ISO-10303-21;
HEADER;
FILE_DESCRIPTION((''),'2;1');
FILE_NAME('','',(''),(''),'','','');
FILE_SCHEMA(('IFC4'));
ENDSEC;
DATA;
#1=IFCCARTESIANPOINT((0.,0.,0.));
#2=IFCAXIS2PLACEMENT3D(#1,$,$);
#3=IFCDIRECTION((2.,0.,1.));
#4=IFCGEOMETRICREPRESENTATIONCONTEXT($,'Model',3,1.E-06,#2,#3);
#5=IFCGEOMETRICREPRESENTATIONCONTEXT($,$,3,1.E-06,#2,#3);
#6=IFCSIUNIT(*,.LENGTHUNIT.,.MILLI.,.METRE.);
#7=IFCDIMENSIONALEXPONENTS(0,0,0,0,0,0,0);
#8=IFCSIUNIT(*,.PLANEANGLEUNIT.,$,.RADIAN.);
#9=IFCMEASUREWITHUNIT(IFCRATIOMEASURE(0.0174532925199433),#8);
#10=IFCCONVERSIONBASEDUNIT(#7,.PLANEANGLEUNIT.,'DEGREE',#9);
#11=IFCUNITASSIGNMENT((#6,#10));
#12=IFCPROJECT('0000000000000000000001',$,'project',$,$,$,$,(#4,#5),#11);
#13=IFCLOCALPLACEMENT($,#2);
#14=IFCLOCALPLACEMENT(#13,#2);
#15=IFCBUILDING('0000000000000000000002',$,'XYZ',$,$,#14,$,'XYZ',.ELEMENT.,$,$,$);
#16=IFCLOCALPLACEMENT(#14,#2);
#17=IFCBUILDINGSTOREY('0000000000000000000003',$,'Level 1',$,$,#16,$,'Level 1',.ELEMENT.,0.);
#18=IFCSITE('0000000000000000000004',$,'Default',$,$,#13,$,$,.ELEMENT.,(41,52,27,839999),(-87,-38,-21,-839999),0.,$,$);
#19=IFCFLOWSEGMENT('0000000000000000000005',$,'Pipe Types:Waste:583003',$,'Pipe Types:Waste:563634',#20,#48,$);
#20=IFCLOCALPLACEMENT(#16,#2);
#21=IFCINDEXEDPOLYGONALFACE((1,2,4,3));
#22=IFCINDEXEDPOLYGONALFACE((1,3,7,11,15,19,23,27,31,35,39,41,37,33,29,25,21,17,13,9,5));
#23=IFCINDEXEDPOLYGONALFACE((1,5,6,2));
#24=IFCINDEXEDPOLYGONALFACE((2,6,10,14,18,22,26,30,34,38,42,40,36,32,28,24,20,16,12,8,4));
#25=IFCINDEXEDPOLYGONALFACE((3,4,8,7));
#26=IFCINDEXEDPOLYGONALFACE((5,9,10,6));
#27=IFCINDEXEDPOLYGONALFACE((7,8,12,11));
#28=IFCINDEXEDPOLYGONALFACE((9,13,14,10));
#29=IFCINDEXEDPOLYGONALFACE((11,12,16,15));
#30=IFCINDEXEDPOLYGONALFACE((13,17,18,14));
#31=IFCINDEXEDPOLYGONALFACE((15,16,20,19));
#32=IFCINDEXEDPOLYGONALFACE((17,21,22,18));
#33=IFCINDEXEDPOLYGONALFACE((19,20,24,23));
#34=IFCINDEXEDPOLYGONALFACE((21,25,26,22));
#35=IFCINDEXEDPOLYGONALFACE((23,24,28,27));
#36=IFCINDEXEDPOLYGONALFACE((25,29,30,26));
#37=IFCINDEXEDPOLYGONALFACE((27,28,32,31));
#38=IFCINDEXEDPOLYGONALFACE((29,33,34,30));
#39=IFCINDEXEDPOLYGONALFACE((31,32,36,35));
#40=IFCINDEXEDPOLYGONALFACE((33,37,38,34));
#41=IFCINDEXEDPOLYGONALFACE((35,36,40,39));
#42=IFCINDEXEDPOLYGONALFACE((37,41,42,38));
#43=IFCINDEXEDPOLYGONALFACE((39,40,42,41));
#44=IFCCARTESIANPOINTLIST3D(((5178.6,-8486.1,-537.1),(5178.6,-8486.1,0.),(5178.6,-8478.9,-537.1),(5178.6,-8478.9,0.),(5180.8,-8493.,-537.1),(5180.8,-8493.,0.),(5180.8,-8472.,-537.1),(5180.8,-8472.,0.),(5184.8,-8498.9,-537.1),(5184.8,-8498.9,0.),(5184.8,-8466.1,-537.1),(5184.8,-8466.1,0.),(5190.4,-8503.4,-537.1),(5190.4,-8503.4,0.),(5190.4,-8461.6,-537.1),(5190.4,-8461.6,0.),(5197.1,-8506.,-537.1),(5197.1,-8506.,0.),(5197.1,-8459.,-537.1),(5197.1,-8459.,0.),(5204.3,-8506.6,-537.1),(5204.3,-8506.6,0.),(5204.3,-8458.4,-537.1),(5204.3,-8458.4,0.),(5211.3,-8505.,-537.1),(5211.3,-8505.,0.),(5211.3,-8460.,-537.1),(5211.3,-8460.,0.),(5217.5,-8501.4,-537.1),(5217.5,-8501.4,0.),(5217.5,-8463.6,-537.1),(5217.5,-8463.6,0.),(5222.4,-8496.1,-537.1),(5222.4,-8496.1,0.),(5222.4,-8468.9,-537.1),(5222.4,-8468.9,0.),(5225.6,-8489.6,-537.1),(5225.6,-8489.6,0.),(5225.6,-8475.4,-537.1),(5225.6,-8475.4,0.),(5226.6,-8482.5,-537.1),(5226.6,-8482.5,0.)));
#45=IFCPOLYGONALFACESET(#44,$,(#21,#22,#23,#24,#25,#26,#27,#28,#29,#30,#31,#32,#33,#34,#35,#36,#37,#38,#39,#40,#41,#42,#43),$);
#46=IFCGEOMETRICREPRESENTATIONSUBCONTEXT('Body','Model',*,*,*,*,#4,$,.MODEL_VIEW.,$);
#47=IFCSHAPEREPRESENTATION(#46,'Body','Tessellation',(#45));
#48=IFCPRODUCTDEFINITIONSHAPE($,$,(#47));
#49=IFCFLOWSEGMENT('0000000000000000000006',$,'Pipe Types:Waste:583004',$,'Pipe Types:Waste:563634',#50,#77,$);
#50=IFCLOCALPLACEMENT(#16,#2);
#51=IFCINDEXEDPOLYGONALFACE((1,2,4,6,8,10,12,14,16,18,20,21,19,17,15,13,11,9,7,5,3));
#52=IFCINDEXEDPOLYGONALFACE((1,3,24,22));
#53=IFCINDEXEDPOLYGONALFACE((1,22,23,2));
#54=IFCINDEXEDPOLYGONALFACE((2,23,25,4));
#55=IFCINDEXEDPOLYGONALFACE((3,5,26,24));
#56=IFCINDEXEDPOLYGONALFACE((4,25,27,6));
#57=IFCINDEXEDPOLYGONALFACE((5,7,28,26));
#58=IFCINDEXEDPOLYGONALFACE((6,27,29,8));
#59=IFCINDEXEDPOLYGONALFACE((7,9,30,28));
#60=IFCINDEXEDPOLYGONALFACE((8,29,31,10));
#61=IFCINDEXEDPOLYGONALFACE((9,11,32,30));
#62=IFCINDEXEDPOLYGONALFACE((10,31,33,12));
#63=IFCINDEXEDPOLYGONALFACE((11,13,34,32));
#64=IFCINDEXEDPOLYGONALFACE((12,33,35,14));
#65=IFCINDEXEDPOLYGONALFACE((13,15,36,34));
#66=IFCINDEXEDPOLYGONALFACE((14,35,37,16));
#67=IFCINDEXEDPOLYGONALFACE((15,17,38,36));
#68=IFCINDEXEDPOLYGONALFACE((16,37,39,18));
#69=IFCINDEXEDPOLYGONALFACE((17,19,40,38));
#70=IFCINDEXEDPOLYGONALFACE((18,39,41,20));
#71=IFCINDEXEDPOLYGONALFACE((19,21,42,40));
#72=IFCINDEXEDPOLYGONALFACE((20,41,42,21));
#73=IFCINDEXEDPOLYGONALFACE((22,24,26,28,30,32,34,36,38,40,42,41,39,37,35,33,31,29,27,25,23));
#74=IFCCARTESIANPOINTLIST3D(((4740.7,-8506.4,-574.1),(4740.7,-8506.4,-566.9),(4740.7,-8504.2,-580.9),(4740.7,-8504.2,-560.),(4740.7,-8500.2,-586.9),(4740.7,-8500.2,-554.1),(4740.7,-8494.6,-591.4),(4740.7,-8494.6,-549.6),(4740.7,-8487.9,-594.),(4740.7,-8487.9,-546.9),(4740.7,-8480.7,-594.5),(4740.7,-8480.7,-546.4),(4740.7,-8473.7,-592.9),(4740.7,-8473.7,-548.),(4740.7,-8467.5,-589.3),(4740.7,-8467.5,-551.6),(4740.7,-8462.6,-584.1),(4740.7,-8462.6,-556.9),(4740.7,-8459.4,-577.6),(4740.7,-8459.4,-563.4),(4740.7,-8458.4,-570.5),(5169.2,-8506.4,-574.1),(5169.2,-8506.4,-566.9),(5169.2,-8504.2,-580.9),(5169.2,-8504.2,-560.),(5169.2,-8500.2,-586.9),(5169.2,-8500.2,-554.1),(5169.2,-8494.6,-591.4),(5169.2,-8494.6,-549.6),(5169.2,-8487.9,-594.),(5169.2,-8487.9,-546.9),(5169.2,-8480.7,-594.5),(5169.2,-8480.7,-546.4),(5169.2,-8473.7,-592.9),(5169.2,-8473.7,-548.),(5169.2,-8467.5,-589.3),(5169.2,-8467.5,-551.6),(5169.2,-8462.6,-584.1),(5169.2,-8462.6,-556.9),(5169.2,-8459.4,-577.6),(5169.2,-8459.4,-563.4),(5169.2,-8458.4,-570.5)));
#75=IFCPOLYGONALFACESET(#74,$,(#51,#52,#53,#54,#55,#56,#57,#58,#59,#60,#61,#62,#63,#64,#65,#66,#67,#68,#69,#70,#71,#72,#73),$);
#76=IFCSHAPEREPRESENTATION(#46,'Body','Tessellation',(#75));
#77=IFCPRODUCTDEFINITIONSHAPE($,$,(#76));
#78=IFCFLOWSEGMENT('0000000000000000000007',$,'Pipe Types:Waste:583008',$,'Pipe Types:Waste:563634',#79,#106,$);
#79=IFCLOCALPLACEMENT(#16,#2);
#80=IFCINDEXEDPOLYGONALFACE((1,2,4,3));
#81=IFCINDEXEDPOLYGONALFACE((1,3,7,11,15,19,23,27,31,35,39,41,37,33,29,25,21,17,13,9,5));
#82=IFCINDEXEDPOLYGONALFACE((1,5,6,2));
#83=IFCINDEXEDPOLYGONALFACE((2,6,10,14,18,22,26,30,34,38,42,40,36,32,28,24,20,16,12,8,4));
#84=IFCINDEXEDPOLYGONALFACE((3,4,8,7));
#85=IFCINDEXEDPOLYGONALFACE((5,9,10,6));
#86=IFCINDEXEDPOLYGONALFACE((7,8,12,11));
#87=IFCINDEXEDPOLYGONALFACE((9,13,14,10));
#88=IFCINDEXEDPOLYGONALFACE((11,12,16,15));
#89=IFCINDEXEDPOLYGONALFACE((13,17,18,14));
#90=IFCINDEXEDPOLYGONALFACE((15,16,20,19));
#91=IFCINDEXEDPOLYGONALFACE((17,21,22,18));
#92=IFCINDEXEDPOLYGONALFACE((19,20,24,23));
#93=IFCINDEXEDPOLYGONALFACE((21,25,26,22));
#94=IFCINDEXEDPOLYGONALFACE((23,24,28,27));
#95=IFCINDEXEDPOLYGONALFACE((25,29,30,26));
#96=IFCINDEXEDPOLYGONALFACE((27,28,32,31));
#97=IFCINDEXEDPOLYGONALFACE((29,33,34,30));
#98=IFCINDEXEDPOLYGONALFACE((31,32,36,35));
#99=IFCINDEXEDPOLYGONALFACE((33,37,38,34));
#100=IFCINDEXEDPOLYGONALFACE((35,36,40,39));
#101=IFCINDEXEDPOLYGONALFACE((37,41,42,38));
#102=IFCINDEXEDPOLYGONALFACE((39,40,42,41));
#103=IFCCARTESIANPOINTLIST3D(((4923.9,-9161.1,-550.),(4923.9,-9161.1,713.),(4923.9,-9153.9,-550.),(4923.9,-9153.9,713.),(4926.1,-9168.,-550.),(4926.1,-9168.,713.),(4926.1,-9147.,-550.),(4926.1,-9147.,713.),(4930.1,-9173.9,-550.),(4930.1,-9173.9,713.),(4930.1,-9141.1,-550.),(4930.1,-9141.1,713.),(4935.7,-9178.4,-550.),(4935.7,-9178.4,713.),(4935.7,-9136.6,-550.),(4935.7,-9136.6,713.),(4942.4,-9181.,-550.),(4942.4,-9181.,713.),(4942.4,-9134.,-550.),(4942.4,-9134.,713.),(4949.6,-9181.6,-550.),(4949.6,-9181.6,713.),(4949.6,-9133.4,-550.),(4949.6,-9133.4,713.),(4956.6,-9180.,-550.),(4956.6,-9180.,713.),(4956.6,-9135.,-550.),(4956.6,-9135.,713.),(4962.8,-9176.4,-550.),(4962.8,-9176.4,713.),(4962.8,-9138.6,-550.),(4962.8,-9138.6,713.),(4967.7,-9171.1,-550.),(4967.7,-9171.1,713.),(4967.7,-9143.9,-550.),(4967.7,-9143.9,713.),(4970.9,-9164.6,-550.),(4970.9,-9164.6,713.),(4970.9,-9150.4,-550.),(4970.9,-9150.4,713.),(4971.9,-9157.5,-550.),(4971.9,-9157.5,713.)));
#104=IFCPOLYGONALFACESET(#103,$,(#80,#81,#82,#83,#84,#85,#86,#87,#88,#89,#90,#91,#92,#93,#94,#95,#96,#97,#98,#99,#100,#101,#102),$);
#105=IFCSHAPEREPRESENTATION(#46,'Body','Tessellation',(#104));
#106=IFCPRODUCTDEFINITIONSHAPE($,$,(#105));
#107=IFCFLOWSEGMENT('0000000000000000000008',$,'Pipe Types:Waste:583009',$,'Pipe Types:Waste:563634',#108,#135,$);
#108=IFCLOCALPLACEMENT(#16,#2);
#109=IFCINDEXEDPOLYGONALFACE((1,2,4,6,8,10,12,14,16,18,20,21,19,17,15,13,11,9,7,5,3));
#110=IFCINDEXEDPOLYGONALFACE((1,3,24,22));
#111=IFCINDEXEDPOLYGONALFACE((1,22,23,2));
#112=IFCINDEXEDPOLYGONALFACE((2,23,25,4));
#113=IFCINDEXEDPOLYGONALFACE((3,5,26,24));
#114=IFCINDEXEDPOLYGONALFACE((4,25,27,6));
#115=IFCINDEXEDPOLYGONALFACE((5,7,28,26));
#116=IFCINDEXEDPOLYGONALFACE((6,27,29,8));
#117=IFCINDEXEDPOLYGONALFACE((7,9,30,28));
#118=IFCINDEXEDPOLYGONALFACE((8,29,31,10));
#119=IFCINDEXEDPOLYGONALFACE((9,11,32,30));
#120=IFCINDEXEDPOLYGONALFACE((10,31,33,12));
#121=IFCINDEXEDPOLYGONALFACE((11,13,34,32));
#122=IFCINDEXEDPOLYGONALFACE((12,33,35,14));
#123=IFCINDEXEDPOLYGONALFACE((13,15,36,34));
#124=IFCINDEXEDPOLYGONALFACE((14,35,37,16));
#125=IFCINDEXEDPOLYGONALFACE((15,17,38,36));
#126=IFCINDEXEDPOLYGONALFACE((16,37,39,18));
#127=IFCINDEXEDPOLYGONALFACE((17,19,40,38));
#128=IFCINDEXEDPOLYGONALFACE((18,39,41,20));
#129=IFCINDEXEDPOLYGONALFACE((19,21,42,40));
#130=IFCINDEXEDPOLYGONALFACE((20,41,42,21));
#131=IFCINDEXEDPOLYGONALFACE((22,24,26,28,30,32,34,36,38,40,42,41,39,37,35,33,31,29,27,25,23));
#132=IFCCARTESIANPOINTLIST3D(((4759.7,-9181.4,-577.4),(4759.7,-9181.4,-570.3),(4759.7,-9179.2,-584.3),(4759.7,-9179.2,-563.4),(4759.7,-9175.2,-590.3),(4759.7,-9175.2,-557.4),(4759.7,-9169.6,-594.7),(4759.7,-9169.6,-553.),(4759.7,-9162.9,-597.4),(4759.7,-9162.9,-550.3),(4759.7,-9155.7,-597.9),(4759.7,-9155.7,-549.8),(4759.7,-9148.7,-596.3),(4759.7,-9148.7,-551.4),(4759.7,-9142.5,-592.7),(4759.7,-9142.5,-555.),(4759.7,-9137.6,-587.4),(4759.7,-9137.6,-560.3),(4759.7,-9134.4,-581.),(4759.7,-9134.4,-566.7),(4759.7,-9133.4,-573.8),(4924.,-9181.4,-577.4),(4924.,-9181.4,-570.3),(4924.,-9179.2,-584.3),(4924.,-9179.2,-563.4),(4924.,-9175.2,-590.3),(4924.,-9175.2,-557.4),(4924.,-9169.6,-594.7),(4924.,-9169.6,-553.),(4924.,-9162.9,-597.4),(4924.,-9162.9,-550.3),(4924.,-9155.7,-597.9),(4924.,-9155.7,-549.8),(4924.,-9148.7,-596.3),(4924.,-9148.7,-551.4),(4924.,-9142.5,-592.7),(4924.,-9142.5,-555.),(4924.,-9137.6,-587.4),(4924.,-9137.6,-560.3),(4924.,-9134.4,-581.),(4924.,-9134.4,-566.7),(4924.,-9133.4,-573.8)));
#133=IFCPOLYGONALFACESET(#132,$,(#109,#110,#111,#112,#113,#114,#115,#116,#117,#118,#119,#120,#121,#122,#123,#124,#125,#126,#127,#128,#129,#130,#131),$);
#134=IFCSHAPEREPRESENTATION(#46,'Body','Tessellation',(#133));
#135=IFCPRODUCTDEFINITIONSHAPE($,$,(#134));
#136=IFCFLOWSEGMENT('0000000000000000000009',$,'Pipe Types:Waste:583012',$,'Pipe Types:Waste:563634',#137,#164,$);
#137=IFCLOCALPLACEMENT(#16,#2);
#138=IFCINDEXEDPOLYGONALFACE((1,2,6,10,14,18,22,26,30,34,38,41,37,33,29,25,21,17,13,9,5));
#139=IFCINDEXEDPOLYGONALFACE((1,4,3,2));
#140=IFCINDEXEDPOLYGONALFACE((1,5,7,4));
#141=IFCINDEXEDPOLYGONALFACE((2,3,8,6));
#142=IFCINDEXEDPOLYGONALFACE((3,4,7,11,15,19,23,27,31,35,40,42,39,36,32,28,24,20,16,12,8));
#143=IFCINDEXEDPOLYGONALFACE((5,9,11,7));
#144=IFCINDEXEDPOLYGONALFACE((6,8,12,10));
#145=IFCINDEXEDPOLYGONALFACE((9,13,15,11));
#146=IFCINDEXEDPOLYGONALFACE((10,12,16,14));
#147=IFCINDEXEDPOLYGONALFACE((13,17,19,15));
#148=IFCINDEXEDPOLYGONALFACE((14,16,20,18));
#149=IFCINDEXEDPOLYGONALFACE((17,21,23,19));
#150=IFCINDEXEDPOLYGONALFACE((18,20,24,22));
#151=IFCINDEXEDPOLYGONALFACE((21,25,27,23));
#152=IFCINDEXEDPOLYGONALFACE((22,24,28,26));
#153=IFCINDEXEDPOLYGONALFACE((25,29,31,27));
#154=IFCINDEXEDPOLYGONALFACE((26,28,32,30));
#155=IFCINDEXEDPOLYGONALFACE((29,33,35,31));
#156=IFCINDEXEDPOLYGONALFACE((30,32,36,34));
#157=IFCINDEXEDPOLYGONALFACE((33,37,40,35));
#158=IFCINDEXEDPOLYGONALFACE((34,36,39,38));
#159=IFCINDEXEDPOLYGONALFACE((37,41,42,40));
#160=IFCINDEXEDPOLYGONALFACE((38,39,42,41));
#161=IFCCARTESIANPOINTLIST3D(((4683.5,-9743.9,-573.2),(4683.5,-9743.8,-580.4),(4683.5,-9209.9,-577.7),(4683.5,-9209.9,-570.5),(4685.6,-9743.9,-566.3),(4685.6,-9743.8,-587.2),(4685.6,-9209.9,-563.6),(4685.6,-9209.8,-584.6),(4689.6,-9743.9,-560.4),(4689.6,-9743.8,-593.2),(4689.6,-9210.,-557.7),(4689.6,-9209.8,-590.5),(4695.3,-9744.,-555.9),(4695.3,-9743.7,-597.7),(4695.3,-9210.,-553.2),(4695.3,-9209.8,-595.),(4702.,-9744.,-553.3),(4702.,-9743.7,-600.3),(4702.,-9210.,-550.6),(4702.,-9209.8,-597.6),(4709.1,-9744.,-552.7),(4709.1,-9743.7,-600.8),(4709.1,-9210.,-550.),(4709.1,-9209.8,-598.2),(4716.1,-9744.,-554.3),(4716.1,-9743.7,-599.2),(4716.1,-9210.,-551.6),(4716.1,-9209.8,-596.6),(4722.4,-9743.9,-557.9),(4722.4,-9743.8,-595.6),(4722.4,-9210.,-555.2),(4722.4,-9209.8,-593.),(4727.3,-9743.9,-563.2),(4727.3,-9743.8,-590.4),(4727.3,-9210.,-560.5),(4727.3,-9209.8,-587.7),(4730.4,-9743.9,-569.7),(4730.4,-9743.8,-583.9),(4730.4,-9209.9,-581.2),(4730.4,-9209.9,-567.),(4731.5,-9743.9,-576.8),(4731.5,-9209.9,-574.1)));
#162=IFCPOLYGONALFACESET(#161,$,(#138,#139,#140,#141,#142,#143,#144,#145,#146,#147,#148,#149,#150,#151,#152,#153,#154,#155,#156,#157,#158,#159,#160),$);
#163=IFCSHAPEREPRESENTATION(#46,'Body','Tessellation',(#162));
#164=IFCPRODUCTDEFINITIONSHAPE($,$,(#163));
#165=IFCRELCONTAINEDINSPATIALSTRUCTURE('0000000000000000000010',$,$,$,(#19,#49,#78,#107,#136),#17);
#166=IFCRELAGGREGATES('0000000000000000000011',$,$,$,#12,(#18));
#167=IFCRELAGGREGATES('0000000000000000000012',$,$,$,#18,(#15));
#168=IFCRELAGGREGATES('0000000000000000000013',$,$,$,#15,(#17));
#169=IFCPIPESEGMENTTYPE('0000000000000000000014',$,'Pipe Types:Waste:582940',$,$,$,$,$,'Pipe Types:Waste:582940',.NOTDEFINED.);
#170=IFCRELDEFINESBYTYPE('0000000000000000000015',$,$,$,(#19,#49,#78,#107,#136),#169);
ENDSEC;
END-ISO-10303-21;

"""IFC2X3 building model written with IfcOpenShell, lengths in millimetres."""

from ifc_helpers import new_model, entity, si_unit, converted_unit, direction, frame, origin, origin_2d_with_axis, place, context, subcontext, project, spatial, circle, extrude, type_object, element, save


model = new_model("IFC2X3")

# Units and contexts
model_context = context("Model", 3, precision=1e-06, world=origin(), true_north=direction((2.0, 0.0, 1.0)))
context_of_model = context(None, 3, precision=1e-06, world=origin(), true_north=direction((2.0, 0.0, 1.0)))
body_context = subcontext(model_context, "Body", "Model", "MODEL_VIEW")
ifc_project = project(units=[si_unit("LENGTHUNIT", "METRE", prefix="MILLI"), converted_unit("PLANEANGLEUNIT", "DEGREE", entity("IfcRatioMeasure", 0.0174532925199433), si_unit("PLANEANGLEUNIT", "RADIAN"), dimensions=[0, 0, 0, 0, 0, 0, 0])], contexts=[model_context, context_of_model])

# Site, building, storey
site_placement = place(None, origin())
site = spatial("IfcSite", under=ifc_project, at=site_placement, Name="Default", CompositionType="ELEMENT", RefLatitude=(41, 52, 27, 839999), RefLongitude=(-87, -38, -21, -839999), RefElevation=0.0)
building_placement = place(site_placement, origin())
building = spatial("IfcBuilding", under=site, at=building_placement, Name="XYZ", LongName="XYZ", CompositionType="ELEMENT")
storey_placement = place(building_placement, origin())
storey = spatial("IfcBuildingStorey", under=building, at=storey_placement, Name="Level 1", LongName="Level 1", CompositionType="ELEMENT", Elevation=0.0)

# Flow segments
pipe_segment_type = type_object("IfcPipeSegmentType", Name="Pipe Types:Waste:582940", ElementType="Pipe Types:Waste:582940", PredefinedType="NOTDEFINED")
flow_segment_1_placement = place(storey_placement, origin())
element("IfcFlowSegment", 1, at=flow_segment_1_placement, inside=storey, type_object=pipe_segment_type, Name="Pipe Types:Waste:583003", ObjectType="Pipe Types:Waste:563634", context=body_context, shape_type="SweptSolid", body=[
    extrude(circle(Radius=24.1, at=origin_2d_with_axis()), frame((5202.5, -8482.5, -537.1)), (0.0, 0.0, 1.0), 537.1),
])
flow_segment_2_placement = place(storey_placement, origin())
element("IfcFlowSegment", 2, at=flow_segment_2_placement, inside=storey, type_object=pipe_segment_type, Name="Pipe Types:Waste:583004", ObjectType="Pipe Types:Waste:563634", context=body_context, shape_type="SweptSolid", body=[
    extrude(circle(Radius=24.1, at=origin_2d_with_axis()), frame((4740.7, -8482.5, -570.5), z_axis=(1.0, 0.0, 0.0), x_axis=(0.0, 1.0, 0.0)), (0.0, 0.0, 1.0), 428.5),
])
flow_segment_3_placement = place(storey_placement, origin())
element("IfcFlowSegment", 3, at=flow_segment_3_placement, inside=storey, type_object=pipe_segment_type, Name="Pipe Types:Waste:583008", ObjectType="Pipe Types:Waste:563634", context=body_context, shape_type="SweptSolid", body=[
    extrude(circle(Radius=24.1, at=origin_2d_with_axis()), frame((4947.8, -9157.5, -550.0)), (0.0, 0.0, 1.0), 1263.0),
])
flow_segment_4_placement = place(storey_placement, origin())
element("IfcFlowSegment", 4, at=flow_segment_4_placement, inside=storey, type_object=pipe_segment_type, Name="Pipe Types:Waste:583009", ObjectType="Pipe Types:Waste:563634", context=body_context, shape_type="SweptSolid", body=[
    extrude(circle(Radius=24.1, at=origin_2d_with_axis()), frame((4759.7, -9157.5, -573.8), z_axis=(1.0, 0.0, 0.0), x_axis=(0.0, 1.0, 0.0)), (0.0, 0.0, 1.0), 164.3),
])
flow_segment_5_placement = place(storey_placement, origin())
element("IfcFlowSegment", 5, at=flow_segment_5_placement, inside=storey, type_object=pipe_segment_type, Name="Pipe Types:Waste:583012", ObjectType="Pipe Types:Waste:563634", context=body_context, shape_type="SweptSolid", body=[
    extrude(circle(Radius=24.1, at=origin_2d_with_axis()), frame((4707.3, -9743.9, -576.8), z_axis=(0.0, 0.999988, 0.005), x_axis=(1.0, 0.0, 0.0)), (0.0, 0.0, 1.0), 534.0),
])

save(model, "model.ifc")
